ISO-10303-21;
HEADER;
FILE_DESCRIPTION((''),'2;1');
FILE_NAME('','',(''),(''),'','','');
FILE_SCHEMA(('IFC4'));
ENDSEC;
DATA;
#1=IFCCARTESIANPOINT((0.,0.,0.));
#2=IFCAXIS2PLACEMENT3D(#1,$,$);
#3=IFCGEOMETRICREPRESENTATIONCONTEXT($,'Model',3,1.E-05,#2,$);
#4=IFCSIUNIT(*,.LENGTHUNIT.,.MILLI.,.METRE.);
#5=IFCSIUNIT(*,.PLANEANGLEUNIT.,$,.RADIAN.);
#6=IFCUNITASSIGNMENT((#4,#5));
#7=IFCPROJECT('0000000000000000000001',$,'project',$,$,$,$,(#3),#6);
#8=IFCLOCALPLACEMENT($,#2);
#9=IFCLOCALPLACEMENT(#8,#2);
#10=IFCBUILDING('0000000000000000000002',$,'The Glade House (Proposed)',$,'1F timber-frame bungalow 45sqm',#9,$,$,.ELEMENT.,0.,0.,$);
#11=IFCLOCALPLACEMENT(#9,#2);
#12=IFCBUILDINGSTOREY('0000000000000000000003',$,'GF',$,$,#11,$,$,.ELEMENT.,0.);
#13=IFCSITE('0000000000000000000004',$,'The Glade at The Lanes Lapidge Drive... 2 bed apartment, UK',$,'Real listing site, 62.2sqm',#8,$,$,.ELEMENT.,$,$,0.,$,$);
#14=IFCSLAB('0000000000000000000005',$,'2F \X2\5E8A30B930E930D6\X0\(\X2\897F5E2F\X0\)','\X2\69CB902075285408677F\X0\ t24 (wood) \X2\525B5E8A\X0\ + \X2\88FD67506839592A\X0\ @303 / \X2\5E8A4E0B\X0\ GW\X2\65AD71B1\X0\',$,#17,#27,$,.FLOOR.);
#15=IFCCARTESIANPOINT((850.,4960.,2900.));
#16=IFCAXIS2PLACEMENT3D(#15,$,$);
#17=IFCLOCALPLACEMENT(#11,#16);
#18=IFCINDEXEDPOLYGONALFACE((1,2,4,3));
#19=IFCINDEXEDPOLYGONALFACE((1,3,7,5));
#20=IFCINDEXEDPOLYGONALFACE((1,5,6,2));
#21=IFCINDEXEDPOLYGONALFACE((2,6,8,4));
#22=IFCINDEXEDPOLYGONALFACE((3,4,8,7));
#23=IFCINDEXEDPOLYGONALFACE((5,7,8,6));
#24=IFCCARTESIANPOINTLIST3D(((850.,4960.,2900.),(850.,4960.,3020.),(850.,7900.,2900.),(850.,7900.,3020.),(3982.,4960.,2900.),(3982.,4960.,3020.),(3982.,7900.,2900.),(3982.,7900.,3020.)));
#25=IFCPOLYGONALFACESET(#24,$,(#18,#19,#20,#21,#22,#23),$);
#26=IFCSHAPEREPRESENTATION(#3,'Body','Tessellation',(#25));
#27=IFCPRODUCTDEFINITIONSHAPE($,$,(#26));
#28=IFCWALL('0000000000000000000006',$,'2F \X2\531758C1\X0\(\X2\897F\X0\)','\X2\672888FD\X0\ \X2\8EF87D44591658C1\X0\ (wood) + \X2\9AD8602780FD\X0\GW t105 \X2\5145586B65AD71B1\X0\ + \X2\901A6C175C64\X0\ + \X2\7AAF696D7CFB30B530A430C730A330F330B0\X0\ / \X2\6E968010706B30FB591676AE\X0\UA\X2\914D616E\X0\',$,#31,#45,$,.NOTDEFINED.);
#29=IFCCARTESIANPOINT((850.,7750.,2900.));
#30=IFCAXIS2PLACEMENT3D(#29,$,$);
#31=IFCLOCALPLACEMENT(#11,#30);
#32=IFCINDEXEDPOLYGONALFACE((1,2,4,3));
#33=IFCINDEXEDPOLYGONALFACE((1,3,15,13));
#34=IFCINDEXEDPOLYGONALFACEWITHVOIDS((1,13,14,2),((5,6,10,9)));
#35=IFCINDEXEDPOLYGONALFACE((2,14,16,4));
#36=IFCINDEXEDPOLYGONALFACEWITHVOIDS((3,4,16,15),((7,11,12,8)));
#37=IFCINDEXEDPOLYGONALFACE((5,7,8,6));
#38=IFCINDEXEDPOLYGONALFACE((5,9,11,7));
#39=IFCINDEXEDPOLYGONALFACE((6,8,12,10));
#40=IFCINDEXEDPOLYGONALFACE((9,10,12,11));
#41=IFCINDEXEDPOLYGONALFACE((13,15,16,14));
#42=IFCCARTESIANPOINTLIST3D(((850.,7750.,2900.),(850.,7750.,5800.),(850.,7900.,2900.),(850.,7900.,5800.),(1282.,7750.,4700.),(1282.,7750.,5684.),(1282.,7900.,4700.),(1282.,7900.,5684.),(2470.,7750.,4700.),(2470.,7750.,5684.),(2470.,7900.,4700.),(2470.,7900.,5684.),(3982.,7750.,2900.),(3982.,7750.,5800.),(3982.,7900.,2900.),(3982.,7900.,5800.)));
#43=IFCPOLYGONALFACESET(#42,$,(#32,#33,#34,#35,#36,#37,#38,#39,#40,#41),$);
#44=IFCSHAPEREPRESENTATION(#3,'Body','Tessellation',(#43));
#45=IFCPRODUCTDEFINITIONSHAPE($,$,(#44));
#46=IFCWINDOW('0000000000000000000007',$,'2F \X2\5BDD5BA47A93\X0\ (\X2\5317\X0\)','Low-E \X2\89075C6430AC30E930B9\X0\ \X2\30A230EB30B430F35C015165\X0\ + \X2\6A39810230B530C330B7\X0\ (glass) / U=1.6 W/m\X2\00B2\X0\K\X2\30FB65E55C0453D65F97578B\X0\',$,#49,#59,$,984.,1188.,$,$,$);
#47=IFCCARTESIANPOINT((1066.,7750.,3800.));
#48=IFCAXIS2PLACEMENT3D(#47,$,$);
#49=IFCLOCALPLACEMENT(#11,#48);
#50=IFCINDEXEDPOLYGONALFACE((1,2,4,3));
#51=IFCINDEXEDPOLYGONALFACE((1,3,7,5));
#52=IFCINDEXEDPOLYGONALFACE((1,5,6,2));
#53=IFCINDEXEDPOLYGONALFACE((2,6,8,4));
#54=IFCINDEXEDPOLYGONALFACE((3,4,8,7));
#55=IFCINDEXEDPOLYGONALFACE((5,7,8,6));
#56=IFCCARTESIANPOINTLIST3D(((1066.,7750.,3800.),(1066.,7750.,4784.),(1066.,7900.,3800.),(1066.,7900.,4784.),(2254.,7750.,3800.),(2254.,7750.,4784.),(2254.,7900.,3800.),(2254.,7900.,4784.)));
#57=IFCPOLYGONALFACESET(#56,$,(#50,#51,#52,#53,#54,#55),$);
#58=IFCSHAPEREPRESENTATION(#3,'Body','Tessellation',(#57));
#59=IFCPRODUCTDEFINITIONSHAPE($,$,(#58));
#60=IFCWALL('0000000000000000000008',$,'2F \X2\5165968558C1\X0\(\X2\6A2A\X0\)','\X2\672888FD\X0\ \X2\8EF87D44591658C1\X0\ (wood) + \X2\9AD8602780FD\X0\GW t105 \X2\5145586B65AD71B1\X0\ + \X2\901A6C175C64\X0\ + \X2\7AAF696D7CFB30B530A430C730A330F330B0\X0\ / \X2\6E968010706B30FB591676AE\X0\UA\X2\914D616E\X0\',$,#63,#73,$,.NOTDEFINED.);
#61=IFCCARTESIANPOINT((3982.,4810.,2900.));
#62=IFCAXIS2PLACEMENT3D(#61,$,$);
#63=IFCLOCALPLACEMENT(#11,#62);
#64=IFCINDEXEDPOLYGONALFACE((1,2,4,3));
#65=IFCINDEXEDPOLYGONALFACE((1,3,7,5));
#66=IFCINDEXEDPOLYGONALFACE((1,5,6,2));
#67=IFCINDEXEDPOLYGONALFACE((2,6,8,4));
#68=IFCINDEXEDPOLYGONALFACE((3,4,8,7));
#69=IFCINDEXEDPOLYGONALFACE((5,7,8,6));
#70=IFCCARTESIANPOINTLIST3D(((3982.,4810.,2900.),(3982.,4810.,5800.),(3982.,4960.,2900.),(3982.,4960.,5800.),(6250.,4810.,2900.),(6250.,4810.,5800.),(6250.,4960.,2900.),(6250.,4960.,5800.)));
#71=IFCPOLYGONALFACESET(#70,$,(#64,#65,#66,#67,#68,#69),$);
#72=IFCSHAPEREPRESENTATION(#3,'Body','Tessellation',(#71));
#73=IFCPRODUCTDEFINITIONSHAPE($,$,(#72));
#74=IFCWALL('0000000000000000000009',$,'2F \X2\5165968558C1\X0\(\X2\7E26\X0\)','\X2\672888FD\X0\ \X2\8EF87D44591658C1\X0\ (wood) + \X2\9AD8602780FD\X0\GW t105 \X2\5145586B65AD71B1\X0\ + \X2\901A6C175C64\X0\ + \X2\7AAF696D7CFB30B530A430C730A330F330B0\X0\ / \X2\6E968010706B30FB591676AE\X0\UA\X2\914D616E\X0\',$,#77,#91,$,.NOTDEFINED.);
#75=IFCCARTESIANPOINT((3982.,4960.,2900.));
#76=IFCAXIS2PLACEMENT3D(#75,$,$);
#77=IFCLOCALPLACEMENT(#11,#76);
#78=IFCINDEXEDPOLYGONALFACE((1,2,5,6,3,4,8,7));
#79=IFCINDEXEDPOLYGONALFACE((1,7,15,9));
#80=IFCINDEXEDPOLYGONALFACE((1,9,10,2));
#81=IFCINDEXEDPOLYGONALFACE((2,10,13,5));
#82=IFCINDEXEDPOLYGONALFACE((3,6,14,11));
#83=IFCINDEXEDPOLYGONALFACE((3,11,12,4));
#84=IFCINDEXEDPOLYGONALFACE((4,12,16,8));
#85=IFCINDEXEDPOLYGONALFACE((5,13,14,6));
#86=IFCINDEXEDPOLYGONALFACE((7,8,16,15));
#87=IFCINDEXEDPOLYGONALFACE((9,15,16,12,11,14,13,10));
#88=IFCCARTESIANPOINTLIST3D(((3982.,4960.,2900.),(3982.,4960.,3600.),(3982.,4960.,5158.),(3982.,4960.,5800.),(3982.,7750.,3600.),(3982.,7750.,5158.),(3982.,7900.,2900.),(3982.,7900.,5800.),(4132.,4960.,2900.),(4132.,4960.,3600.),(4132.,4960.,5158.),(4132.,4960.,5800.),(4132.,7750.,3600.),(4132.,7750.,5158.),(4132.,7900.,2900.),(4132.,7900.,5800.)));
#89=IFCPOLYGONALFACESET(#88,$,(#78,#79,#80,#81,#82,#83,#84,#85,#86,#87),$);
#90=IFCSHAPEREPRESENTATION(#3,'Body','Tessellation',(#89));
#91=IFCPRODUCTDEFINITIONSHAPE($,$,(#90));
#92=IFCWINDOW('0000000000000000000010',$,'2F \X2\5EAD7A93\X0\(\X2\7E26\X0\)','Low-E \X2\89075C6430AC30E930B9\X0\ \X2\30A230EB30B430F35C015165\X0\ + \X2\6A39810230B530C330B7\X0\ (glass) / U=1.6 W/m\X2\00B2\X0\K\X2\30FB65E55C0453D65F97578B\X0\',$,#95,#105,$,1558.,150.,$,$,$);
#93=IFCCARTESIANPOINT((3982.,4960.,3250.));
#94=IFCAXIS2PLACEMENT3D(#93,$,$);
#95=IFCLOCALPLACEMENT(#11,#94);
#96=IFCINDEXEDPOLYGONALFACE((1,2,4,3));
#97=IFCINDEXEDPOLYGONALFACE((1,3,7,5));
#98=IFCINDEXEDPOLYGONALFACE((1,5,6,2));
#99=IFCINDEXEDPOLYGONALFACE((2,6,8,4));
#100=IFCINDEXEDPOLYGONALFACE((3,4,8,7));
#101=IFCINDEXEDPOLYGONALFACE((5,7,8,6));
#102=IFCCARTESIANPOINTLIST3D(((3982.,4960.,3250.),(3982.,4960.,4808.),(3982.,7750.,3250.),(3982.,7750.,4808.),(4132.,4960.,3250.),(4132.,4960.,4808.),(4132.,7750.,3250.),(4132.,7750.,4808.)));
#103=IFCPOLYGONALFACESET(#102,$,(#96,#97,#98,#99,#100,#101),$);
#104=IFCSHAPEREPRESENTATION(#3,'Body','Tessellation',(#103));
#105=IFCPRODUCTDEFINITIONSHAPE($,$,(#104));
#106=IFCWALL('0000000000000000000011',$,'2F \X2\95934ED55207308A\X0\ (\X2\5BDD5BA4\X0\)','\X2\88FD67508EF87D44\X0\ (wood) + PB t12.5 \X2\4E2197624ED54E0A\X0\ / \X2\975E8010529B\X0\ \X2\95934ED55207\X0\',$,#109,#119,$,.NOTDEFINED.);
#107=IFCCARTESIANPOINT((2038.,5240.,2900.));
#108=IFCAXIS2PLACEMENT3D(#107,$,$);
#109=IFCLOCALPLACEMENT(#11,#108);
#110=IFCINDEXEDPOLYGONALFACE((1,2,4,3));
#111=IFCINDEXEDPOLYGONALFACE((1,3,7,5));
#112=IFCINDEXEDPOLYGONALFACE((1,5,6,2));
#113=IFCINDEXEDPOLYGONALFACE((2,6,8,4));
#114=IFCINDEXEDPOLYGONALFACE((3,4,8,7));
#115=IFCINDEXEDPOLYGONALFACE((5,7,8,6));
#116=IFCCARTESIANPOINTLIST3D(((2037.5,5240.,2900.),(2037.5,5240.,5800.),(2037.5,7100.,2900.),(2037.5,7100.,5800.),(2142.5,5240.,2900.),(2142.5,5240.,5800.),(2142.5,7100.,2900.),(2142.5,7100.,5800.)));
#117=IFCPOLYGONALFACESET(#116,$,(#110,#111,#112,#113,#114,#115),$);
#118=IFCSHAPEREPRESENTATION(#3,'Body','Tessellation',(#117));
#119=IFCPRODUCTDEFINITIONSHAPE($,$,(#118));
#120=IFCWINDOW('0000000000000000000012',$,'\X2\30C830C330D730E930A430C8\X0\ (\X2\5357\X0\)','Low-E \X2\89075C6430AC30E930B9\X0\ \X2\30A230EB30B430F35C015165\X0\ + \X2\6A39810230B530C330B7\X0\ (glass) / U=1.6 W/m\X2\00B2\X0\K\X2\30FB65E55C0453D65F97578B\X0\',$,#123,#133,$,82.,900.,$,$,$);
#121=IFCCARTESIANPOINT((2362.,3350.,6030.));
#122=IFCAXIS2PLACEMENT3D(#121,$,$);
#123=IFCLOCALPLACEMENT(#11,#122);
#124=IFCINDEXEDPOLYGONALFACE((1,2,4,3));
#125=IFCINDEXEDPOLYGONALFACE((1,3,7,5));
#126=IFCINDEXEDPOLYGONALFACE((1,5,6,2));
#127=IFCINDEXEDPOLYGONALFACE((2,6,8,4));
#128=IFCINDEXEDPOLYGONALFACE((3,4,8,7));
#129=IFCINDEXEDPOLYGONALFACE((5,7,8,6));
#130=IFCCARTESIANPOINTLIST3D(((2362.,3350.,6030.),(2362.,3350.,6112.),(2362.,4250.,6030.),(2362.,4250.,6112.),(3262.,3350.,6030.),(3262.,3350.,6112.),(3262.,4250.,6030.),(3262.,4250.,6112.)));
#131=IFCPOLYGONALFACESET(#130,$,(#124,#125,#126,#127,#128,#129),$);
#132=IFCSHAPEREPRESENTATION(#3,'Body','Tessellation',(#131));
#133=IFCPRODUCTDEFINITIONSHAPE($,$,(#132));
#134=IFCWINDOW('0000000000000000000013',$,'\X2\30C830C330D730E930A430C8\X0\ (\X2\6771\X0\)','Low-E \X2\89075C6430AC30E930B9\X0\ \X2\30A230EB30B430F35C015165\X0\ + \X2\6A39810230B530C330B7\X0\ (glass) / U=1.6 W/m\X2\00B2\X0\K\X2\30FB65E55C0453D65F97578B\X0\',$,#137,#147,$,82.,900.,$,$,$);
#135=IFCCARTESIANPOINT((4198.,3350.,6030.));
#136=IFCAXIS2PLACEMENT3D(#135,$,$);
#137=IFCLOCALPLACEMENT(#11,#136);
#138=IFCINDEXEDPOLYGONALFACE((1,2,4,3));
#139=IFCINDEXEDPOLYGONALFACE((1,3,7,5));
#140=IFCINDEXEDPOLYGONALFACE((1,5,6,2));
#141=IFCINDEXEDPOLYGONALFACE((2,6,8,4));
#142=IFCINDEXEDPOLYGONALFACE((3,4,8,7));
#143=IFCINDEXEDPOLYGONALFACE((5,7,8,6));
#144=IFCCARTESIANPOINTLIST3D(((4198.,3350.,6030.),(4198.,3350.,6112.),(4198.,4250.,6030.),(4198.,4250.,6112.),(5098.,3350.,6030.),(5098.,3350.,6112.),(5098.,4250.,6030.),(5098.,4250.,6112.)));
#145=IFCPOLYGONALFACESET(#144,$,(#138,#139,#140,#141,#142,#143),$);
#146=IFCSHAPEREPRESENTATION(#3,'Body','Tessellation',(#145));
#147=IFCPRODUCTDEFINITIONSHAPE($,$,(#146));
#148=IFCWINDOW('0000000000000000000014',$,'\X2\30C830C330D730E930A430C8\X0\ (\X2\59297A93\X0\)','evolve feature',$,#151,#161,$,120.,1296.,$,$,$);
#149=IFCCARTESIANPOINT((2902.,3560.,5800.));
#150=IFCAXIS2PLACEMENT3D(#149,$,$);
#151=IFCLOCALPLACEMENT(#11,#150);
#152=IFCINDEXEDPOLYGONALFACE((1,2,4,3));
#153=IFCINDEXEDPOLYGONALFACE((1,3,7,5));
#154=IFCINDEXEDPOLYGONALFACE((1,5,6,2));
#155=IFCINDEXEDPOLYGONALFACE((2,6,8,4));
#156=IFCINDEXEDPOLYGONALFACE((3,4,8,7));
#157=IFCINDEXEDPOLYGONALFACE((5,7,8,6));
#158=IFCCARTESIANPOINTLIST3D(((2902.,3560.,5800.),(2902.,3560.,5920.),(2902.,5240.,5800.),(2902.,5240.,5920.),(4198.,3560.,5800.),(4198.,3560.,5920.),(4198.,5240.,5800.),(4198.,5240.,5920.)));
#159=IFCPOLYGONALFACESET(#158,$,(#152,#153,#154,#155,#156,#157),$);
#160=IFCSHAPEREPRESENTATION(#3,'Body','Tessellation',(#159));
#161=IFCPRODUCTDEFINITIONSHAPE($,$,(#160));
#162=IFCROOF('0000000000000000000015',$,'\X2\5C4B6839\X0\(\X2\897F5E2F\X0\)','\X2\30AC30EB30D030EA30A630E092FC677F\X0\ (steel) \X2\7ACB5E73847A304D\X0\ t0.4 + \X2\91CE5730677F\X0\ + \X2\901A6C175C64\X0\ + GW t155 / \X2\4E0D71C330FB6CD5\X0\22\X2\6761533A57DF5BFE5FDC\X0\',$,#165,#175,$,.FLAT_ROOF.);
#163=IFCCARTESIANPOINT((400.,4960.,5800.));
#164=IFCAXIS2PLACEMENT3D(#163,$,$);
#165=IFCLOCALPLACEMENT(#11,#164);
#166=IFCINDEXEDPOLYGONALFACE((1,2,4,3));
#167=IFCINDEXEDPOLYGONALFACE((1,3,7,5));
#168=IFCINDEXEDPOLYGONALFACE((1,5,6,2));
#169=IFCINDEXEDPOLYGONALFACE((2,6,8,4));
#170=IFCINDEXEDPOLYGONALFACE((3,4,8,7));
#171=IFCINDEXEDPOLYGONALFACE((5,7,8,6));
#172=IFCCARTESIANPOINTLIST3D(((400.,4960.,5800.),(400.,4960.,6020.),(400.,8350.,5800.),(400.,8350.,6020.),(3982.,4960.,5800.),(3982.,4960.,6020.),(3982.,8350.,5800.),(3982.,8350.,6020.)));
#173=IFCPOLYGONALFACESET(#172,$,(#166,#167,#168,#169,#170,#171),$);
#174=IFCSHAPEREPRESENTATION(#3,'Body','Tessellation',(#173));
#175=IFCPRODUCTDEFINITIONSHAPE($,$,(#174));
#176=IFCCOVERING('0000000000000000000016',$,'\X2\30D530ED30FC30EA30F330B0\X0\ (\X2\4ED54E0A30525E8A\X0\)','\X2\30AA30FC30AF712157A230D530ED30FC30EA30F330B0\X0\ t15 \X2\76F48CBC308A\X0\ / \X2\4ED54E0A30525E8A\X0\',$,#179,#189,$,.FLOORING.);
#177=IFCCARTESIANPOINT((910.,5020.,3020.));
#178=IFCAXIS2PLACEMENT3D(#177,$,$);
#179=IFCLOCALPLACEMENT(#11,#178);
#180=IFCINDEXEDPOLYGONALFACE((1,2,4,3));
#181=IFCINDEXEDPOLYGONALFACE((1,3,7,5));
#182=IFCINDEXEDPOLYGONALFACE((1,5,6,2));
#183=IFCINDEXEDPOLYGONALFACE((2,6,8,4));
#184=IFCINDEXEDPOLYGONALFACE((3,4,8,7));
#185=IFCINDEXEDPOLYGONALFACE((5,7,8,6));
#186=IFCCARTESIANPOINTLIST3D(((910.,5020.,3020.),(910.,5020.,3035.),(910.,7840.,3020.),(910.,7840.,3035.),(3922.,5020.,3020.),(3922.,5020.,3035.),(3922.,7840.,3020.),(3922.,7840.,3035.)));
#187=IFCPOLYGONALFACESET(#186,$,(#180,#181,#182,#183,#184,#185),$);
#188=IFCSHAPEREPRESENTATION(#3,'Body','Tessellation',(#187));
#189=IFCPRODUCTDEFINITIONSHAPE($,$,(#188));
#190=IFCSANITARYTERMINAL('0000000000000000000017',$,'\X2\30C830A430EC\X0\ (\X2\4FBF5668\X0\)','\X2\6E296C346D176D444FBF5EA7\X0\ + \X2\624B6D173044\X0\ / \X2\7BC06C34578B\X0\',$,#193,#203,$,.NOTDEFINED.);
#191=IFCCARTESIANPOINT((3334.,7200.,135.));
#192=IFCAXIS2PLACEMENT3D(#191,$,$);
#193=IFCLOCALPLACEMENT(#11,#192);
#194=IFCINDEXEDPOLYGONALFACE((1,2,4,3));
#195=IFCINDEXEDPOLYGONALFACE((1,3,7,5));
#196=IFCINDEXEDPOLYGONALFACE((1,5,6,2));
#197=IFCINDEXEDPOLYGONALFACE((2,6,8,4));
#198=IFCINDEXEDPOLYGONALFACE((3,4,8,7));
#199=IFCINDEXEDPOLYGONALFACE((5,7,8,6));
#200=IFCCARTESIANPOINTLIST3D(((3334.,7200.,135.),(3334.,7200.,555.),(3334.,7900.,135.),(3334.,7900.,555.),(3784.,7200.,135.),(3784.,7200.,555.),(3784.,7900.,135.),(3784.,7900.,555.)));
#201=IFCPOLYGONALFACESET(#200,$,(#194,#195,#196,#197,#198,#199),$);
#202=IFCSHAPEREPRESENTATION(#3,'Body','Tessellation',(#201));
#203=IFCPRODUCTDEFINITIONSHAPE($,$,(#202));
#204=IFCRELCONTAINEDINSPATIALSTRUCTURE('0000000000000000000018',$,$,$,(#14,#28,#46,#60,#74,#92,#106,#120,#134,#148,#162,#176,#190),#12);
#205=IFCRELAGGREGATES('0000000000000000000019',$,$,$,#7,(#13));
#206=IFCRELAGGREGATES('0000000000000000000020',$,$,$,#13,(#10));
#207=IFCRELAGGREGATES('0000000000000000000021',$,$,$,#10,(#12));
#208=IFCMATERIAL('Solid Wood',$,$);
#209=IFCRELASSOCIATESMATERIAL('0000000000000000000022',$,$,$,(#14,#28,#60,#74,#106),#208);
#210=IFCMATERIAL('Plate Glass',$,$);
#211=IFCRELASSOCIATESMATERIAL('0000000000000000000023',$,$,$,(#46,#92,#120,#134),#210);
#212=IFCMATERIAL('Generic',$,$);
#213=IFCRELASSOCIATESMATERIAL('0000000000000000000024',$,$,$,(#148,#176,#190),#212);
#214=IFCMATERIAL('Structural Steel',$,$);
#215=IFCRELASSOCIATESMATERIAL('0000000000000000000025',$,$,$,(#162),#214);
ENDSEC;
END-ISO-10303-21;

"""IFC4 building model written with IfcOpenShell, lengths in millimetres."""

from ifc_helpers import new_model, si_unit, frame, frame_2d, origin, place, context, project, spatial, rectangle, extrude, material, element, fill, save


model = new_model("IFC4")

# Units and contexts
model_context = context("Model", 3, precision=1e-05, world=origin())
ifc_project = project(units=[si_unit("LENGTHUNIT", "METRE", prefix="MILLI"), si_unit("PLANEANGLEUNIT", "RADIAN")], contexts=[model_context])

# Site, building, storey
site_placement = place(None, origin())
site = spatial("IfcSite", under=ifc_project, at=site_placement, Name="The Glade at The Lanes Lapidge Drive... 2 bed apartment, UK", ObjectType="Real listing site, 62.2sqm", CompositionType="ELEMENT", RefElevation=0.0)
building_placement = place(site_placement, origin())
building = spatial("IfcBuilding", under=site, at=building_placement, Name="The Glade House (Proposed)", ObjectType="1F timber-frame bungalow 45sqm", CompositionType="ELEMENT", ElevationOfRefHeight=0.0, ElevationOfTerrain=0.0)
storey_placement = place(building_placement, origin())
storey = spatial("IfcBuildingStorey", under=building, at=storey_placement, Name="GF", CompositionType="ELEMENT", Elevation=0.0)

# Slab
ifc_material_1 = material(Name="Solid Wood")
slab_placement = place(storey_placement, frame((850.0, 4960.0, 2900.0)))
element("IfcSlab", 1, at=slab_placement, inside=storey, material=ifc_material_1, Name="2F 床スラブ(西帯)", Description="構造用合板 t24 (wood) 剛床 + 製材根太 @303 / 床下 GW断熱", PredefinedType="FLOOR", context=model_context, shape_type="SweptSolid", body=[
    extrude(rectangle(XDim=3132.0, YDim=2940.0, at=frame_2d((1566.0, 1470.0))), frame((850.0, 4960.0, 2900.0)), (0.0, 0.0, 1.0), 120.0),
])

# Wall, opening, window
wall_1_placement = place(storey_placement, frame((850.0, 7750.0, 2900.0)))
wall_1 = element("IfcWall", 2, at=wall_1_placement, inside=storey, material=ifc_material_1, Name="2F 北壁(西)", Description="木製 軸組外壁 (wood) + 高性能GW t105 充填断熱 + 通気層 + 窯業系サイディング / 準耐火・外皮UA配慮", PredefinedType="NOTDEFINED", context=model_context, shape_type="SweptSolid", body=[
    extrude(rectangle(XDim=3132.0, YDim=150.0, at=frame_2d((1566.0, 75.0))), frame((850.0, 7750.0, 2900.0)), (0.0, 0.0, 1.0), 2900.0),
])
opening_1_placement = place(storey_placement, frame((1066.0, 7750.0, 3800.0)))
opening_1 = element("IfcOpeningElement", 3, at=opening_1_placement, cuts=wall_1, PredefinedType="NOTDEFINED", context=model_context, shape_type="SweptSolid", body=[
    extrude(rectangle(XDim=1188.0, YDim=150.0, at=frame_2d((594.0, 75.0))), frame((1066.0, 7750.0, 3800.0)), (0.0, 0.0, 1.0), 984.0),
])
ifc_material_2 = material(Name="Plate Glass")
window_1_placement = place(storey_placement, frame((1066.0, 7750.0, 3800.0)))
window_1 = element("IfcWindow", 4, at=window_1_placement, inside=storey, material=ifc_material_2, Name="2F 寝室窓 (北)", Description="Low-E 複層ガラス アルゴン封入 + 樹脂サッシ (glass) / U=1.6 W/m²K・日射取得型", OverallHeight=984.0, OverallWidth=1188.0, context=model_context, shape_type="SweptSolid", body=[
    extrude(rectangle(XDim=1188.0, YDim=150.0, at=frame_2d((594.0, 75.0))), frame((1066.0, 7750.0, 3800.0)), (0.0, 0.0, 1.0), 984.0),
])
fill(opening_1, window_1)

# Wall
wall_2_placement = place(storey_placement, frame((3982.0, 4810.0, 2900.0)))
element("IfcWall", 5, at=wall_2_placement, inside=storey, material=ifc_material_1, Name="2F 入隅壁(横)", Description="木製 軸組外壁 (wood) + 高性能GW t105 充填断熱 + 通気層 + 窯業系サイディング / 準耐火・外皮UA配慮", PredefinedType="NOTDEFINED", context=model_context, shape_type="SweptSolid", body=[
    extrude(rectangle(XDim=2268.0, YDim=150.0, at=frame_2d((1134.0, 75.0))), frame((3982.0, 4810.0, 2900.0)), (0.0, 0.0, 1.0), 2900.0),
])

# Wall, opening, window
wall_3_placement = place(storey_placement, frame((3982.0, 4960.0, 2900.0)))
wall_3 = element("IfcWall", 6, at=wall_3_placement, inside=storey, material=ifc_material_1, Name="2F 入隅壁(縦)", Description="木製 軸組外壁 (wood) + 高性能GW t105 充填断熱 + 通気層 + 窯業系サイディング / 準耐火・外皮UA配慮", PredefinedType="NOTDEFINED", context=model_context, shape_type="SweptSolid", body=[
    extrude(rectangle(XDim=150.0, YDim=2940.0, at=frame_2d((75.0, 1470.0))), frame((3982.0, 4960.0, 2900.0)), (0.0, 0.0, 1.0), 2900.0),
])
opening_2_placement = place(storey_placement, frame((3982.0, 4960.0, 3250.0)))
opening_2 = element("IfcOpeningElement", 7, at=opening_2_placement, cuts=wall_3, PredefinedType="NOTDEFINED", context=model_context, shape_type="SweptSolid", body=[
    extrude(rectangle(XDim=150.0, YDim=2790.0, at=frame_2d((75.0, 1395.0))), frame((3982.0, 4960.0, 3250.0)), (0.0, 0.0, 1.0), 1558.0),
])
window_2_placement = place(storey_placement, frame((3982.0, 4960.0, 3250.0)))
window_2 = element("IfcWindow", 8, at=window_2_placement, inside=storey, material=ifc_material_2, Name="2F 庭窓(縦)", Description="Low-E 複層ガラス アルゴン封入 + 樹脂サッシ (glass) / U=1.6 W/m²K・日射取得型", OverallHeight=1558.0, OverallWidth=150.0, context=model_context, shape_type="SweptSolid", body=[
    extrude(rectangle(XDim=150.0, YDim=2790.0, at=frame_2d((75.0, 1395.0))), frame((3982.0, 4960.0, 3250.0)), (0.0, 0.0, 1.0), 1558.0),
])
fill(opening_2, window_2)

# Wall
wall_4_placement = place(storey_placement, frame((2038.0, 5240.0, 2900.0)))
element("IfcWall", 9, at=wall_4_placement, inside=storey, material=ifc_material_1, Name="2F 間仕切り (寝室)", Description="製材軸組 (wood) + PB t12.5 両面仕上 / 非耐力 間仕切", PredefinedType="NOTDEFINED", context=model_context, shape_type="SweptSolid", body=[
    extrude(rectangle(XDim=105.0, YDim=1860.0, at=frame_2d((52.0, 930.0))), frame((2038.0, 5240.0, 2900.0)), (0.0, 0.0, 1.0), 2900.0),
])

# Windows
window_3_placement = place(storey_placement, frame((2362.0, 3350.0, 6030.0)))
element("IfcWindow", 10, at=window_3_placement, inside=storey, material=ifc_material_2, Name="トップライト (南)", Description="Low-E 複層ガラス アルゴン封入 + 樹脂サッシ (glass) / U=1.6 W/m²K・日射取得型", OverallHeight=82.0, OverallWidth=900.0, context=model_context, shape_type="SweptSolid", body=[
    extrude(rectangle(XDim=900.0, YDim=900.0, at=frame_2d((450.0, 450.0))), frame((2362.0, 3350.0, 6030.0)), (0.0, 0.0, 1.0), 82.0),
])
window_4_placement = place(storey_placement, frame((4198.0, 3350.0, 6030.0)))
element("IfcWindow", 11, at=window_4_placement, inside=storey, material=ifc_material_2, Name="トップライト (東)", Description="Low-E 複層ガラス アルゴン封入 + 樹脂サッシ (glass) / U=1.6 W/m²K・日射取得型", OverallHeight=82.0, OverallWidth=900.0, context=model_context, shape_type="SweptSolid", body=[
    extrude(rectangle(XDim=900.0, YDim=900.0, at=frame_2d((450.0, 450.0))), frame((4198.0, 3350.0, 6030.0)), (0.0, 0.0, 1.0), 82.0),
])
ifc_material_3 = material(Name="Generic")
window_5_placement = place(storey_placement, frame((2902.0, 3560.0, 5800.0)))
element("IfcWindow", 12, at=window_5_placement, inside=storey, material=ifc_material_3, Name="トップライト (天窓)", Description="evolve feature", OverallHeight=120.0, OverallWidth=1296.0, context=model_context, shape_type="SweptSolid", body=[
    extrude(rectangle(XDim=1296.0, YDim=1680.0, at=frame_2d((648.0, 840.0))), frame((2902.0, 3560.0, 5800.0)), (0.0, 0.0, 1.0), 120.0),
])

# Roof
ifc_material_4 = material(Name="Structural Steel")
for number, where, name in (
    (13, (400.0, 4960.0, 5800.0), "屋根(西帯)"),
):
    element("IfcRoof", number, at=place(storey_placement, frame(where)), inside=storey, material=ifc_material_4, Name=name, Description="ガルバリウム鋼板 (steel) 立平葺き t0.4 + 野地板 + 通気層 + GW t155 / 不燃・法22条区域対応", PredefinedType="FLAT_ROOF", context=model_context, shape_type="SweptSolid", body=[
        extrude(rectangle(XDim=3582.0, YDim=3390.0, at=frame_2d((1791.0, 1695.0))), frame((400.0, 4960.0, 5800.0)), (0.0, 0.0, 1.0), 220.0),
    ])

# Covering
covering_placement = place(storey_placement, frame((910.0, 5020.0, 3020.0)))
element("IfcCovering", 14, at=covering_placement, inside=storey, material=ifc_material_3, Name="フローリング (仕上げ床)", Description="オーク無垢フローリング t15 直貼り / 仕上げ床", PredefinedType="FLOORING", context=model_context, shape_type="SweptSolid", body=[
    extrude(rectangle(XDim=3012.0, YDim=2820.0, at=frame_2d((1506.0, 1410.0))), frame((910.0, 5020.0, 3020.0)), (0.0, 0.0, 1.0), 15.0),
])

# Sanitary terminal
sanitary_terminal_placement = place(storey_placement, frame((3334.0, 7200.0, 135.0)))
element("IfcSanitaryTerminal", 15, at=sanitary_terminal_placement, inside=storey, material=ifc_material_3, Name="トイレ (便器)", Description="温水洗浄便座 + 手洗い / 節水型", PredefinedType="NOTDEFINED", context=model_context, shape_type="SweptSolid", body=[
    extrude(rectangle(XDim=450.0, YDim=700.0, at=frame_2d((225.0, 350.0))), frame((3334.0, 7200.0, 135.0)), (0.0, 0.0, 1.0), 420.0),
])

save(model, "model.ifc")
